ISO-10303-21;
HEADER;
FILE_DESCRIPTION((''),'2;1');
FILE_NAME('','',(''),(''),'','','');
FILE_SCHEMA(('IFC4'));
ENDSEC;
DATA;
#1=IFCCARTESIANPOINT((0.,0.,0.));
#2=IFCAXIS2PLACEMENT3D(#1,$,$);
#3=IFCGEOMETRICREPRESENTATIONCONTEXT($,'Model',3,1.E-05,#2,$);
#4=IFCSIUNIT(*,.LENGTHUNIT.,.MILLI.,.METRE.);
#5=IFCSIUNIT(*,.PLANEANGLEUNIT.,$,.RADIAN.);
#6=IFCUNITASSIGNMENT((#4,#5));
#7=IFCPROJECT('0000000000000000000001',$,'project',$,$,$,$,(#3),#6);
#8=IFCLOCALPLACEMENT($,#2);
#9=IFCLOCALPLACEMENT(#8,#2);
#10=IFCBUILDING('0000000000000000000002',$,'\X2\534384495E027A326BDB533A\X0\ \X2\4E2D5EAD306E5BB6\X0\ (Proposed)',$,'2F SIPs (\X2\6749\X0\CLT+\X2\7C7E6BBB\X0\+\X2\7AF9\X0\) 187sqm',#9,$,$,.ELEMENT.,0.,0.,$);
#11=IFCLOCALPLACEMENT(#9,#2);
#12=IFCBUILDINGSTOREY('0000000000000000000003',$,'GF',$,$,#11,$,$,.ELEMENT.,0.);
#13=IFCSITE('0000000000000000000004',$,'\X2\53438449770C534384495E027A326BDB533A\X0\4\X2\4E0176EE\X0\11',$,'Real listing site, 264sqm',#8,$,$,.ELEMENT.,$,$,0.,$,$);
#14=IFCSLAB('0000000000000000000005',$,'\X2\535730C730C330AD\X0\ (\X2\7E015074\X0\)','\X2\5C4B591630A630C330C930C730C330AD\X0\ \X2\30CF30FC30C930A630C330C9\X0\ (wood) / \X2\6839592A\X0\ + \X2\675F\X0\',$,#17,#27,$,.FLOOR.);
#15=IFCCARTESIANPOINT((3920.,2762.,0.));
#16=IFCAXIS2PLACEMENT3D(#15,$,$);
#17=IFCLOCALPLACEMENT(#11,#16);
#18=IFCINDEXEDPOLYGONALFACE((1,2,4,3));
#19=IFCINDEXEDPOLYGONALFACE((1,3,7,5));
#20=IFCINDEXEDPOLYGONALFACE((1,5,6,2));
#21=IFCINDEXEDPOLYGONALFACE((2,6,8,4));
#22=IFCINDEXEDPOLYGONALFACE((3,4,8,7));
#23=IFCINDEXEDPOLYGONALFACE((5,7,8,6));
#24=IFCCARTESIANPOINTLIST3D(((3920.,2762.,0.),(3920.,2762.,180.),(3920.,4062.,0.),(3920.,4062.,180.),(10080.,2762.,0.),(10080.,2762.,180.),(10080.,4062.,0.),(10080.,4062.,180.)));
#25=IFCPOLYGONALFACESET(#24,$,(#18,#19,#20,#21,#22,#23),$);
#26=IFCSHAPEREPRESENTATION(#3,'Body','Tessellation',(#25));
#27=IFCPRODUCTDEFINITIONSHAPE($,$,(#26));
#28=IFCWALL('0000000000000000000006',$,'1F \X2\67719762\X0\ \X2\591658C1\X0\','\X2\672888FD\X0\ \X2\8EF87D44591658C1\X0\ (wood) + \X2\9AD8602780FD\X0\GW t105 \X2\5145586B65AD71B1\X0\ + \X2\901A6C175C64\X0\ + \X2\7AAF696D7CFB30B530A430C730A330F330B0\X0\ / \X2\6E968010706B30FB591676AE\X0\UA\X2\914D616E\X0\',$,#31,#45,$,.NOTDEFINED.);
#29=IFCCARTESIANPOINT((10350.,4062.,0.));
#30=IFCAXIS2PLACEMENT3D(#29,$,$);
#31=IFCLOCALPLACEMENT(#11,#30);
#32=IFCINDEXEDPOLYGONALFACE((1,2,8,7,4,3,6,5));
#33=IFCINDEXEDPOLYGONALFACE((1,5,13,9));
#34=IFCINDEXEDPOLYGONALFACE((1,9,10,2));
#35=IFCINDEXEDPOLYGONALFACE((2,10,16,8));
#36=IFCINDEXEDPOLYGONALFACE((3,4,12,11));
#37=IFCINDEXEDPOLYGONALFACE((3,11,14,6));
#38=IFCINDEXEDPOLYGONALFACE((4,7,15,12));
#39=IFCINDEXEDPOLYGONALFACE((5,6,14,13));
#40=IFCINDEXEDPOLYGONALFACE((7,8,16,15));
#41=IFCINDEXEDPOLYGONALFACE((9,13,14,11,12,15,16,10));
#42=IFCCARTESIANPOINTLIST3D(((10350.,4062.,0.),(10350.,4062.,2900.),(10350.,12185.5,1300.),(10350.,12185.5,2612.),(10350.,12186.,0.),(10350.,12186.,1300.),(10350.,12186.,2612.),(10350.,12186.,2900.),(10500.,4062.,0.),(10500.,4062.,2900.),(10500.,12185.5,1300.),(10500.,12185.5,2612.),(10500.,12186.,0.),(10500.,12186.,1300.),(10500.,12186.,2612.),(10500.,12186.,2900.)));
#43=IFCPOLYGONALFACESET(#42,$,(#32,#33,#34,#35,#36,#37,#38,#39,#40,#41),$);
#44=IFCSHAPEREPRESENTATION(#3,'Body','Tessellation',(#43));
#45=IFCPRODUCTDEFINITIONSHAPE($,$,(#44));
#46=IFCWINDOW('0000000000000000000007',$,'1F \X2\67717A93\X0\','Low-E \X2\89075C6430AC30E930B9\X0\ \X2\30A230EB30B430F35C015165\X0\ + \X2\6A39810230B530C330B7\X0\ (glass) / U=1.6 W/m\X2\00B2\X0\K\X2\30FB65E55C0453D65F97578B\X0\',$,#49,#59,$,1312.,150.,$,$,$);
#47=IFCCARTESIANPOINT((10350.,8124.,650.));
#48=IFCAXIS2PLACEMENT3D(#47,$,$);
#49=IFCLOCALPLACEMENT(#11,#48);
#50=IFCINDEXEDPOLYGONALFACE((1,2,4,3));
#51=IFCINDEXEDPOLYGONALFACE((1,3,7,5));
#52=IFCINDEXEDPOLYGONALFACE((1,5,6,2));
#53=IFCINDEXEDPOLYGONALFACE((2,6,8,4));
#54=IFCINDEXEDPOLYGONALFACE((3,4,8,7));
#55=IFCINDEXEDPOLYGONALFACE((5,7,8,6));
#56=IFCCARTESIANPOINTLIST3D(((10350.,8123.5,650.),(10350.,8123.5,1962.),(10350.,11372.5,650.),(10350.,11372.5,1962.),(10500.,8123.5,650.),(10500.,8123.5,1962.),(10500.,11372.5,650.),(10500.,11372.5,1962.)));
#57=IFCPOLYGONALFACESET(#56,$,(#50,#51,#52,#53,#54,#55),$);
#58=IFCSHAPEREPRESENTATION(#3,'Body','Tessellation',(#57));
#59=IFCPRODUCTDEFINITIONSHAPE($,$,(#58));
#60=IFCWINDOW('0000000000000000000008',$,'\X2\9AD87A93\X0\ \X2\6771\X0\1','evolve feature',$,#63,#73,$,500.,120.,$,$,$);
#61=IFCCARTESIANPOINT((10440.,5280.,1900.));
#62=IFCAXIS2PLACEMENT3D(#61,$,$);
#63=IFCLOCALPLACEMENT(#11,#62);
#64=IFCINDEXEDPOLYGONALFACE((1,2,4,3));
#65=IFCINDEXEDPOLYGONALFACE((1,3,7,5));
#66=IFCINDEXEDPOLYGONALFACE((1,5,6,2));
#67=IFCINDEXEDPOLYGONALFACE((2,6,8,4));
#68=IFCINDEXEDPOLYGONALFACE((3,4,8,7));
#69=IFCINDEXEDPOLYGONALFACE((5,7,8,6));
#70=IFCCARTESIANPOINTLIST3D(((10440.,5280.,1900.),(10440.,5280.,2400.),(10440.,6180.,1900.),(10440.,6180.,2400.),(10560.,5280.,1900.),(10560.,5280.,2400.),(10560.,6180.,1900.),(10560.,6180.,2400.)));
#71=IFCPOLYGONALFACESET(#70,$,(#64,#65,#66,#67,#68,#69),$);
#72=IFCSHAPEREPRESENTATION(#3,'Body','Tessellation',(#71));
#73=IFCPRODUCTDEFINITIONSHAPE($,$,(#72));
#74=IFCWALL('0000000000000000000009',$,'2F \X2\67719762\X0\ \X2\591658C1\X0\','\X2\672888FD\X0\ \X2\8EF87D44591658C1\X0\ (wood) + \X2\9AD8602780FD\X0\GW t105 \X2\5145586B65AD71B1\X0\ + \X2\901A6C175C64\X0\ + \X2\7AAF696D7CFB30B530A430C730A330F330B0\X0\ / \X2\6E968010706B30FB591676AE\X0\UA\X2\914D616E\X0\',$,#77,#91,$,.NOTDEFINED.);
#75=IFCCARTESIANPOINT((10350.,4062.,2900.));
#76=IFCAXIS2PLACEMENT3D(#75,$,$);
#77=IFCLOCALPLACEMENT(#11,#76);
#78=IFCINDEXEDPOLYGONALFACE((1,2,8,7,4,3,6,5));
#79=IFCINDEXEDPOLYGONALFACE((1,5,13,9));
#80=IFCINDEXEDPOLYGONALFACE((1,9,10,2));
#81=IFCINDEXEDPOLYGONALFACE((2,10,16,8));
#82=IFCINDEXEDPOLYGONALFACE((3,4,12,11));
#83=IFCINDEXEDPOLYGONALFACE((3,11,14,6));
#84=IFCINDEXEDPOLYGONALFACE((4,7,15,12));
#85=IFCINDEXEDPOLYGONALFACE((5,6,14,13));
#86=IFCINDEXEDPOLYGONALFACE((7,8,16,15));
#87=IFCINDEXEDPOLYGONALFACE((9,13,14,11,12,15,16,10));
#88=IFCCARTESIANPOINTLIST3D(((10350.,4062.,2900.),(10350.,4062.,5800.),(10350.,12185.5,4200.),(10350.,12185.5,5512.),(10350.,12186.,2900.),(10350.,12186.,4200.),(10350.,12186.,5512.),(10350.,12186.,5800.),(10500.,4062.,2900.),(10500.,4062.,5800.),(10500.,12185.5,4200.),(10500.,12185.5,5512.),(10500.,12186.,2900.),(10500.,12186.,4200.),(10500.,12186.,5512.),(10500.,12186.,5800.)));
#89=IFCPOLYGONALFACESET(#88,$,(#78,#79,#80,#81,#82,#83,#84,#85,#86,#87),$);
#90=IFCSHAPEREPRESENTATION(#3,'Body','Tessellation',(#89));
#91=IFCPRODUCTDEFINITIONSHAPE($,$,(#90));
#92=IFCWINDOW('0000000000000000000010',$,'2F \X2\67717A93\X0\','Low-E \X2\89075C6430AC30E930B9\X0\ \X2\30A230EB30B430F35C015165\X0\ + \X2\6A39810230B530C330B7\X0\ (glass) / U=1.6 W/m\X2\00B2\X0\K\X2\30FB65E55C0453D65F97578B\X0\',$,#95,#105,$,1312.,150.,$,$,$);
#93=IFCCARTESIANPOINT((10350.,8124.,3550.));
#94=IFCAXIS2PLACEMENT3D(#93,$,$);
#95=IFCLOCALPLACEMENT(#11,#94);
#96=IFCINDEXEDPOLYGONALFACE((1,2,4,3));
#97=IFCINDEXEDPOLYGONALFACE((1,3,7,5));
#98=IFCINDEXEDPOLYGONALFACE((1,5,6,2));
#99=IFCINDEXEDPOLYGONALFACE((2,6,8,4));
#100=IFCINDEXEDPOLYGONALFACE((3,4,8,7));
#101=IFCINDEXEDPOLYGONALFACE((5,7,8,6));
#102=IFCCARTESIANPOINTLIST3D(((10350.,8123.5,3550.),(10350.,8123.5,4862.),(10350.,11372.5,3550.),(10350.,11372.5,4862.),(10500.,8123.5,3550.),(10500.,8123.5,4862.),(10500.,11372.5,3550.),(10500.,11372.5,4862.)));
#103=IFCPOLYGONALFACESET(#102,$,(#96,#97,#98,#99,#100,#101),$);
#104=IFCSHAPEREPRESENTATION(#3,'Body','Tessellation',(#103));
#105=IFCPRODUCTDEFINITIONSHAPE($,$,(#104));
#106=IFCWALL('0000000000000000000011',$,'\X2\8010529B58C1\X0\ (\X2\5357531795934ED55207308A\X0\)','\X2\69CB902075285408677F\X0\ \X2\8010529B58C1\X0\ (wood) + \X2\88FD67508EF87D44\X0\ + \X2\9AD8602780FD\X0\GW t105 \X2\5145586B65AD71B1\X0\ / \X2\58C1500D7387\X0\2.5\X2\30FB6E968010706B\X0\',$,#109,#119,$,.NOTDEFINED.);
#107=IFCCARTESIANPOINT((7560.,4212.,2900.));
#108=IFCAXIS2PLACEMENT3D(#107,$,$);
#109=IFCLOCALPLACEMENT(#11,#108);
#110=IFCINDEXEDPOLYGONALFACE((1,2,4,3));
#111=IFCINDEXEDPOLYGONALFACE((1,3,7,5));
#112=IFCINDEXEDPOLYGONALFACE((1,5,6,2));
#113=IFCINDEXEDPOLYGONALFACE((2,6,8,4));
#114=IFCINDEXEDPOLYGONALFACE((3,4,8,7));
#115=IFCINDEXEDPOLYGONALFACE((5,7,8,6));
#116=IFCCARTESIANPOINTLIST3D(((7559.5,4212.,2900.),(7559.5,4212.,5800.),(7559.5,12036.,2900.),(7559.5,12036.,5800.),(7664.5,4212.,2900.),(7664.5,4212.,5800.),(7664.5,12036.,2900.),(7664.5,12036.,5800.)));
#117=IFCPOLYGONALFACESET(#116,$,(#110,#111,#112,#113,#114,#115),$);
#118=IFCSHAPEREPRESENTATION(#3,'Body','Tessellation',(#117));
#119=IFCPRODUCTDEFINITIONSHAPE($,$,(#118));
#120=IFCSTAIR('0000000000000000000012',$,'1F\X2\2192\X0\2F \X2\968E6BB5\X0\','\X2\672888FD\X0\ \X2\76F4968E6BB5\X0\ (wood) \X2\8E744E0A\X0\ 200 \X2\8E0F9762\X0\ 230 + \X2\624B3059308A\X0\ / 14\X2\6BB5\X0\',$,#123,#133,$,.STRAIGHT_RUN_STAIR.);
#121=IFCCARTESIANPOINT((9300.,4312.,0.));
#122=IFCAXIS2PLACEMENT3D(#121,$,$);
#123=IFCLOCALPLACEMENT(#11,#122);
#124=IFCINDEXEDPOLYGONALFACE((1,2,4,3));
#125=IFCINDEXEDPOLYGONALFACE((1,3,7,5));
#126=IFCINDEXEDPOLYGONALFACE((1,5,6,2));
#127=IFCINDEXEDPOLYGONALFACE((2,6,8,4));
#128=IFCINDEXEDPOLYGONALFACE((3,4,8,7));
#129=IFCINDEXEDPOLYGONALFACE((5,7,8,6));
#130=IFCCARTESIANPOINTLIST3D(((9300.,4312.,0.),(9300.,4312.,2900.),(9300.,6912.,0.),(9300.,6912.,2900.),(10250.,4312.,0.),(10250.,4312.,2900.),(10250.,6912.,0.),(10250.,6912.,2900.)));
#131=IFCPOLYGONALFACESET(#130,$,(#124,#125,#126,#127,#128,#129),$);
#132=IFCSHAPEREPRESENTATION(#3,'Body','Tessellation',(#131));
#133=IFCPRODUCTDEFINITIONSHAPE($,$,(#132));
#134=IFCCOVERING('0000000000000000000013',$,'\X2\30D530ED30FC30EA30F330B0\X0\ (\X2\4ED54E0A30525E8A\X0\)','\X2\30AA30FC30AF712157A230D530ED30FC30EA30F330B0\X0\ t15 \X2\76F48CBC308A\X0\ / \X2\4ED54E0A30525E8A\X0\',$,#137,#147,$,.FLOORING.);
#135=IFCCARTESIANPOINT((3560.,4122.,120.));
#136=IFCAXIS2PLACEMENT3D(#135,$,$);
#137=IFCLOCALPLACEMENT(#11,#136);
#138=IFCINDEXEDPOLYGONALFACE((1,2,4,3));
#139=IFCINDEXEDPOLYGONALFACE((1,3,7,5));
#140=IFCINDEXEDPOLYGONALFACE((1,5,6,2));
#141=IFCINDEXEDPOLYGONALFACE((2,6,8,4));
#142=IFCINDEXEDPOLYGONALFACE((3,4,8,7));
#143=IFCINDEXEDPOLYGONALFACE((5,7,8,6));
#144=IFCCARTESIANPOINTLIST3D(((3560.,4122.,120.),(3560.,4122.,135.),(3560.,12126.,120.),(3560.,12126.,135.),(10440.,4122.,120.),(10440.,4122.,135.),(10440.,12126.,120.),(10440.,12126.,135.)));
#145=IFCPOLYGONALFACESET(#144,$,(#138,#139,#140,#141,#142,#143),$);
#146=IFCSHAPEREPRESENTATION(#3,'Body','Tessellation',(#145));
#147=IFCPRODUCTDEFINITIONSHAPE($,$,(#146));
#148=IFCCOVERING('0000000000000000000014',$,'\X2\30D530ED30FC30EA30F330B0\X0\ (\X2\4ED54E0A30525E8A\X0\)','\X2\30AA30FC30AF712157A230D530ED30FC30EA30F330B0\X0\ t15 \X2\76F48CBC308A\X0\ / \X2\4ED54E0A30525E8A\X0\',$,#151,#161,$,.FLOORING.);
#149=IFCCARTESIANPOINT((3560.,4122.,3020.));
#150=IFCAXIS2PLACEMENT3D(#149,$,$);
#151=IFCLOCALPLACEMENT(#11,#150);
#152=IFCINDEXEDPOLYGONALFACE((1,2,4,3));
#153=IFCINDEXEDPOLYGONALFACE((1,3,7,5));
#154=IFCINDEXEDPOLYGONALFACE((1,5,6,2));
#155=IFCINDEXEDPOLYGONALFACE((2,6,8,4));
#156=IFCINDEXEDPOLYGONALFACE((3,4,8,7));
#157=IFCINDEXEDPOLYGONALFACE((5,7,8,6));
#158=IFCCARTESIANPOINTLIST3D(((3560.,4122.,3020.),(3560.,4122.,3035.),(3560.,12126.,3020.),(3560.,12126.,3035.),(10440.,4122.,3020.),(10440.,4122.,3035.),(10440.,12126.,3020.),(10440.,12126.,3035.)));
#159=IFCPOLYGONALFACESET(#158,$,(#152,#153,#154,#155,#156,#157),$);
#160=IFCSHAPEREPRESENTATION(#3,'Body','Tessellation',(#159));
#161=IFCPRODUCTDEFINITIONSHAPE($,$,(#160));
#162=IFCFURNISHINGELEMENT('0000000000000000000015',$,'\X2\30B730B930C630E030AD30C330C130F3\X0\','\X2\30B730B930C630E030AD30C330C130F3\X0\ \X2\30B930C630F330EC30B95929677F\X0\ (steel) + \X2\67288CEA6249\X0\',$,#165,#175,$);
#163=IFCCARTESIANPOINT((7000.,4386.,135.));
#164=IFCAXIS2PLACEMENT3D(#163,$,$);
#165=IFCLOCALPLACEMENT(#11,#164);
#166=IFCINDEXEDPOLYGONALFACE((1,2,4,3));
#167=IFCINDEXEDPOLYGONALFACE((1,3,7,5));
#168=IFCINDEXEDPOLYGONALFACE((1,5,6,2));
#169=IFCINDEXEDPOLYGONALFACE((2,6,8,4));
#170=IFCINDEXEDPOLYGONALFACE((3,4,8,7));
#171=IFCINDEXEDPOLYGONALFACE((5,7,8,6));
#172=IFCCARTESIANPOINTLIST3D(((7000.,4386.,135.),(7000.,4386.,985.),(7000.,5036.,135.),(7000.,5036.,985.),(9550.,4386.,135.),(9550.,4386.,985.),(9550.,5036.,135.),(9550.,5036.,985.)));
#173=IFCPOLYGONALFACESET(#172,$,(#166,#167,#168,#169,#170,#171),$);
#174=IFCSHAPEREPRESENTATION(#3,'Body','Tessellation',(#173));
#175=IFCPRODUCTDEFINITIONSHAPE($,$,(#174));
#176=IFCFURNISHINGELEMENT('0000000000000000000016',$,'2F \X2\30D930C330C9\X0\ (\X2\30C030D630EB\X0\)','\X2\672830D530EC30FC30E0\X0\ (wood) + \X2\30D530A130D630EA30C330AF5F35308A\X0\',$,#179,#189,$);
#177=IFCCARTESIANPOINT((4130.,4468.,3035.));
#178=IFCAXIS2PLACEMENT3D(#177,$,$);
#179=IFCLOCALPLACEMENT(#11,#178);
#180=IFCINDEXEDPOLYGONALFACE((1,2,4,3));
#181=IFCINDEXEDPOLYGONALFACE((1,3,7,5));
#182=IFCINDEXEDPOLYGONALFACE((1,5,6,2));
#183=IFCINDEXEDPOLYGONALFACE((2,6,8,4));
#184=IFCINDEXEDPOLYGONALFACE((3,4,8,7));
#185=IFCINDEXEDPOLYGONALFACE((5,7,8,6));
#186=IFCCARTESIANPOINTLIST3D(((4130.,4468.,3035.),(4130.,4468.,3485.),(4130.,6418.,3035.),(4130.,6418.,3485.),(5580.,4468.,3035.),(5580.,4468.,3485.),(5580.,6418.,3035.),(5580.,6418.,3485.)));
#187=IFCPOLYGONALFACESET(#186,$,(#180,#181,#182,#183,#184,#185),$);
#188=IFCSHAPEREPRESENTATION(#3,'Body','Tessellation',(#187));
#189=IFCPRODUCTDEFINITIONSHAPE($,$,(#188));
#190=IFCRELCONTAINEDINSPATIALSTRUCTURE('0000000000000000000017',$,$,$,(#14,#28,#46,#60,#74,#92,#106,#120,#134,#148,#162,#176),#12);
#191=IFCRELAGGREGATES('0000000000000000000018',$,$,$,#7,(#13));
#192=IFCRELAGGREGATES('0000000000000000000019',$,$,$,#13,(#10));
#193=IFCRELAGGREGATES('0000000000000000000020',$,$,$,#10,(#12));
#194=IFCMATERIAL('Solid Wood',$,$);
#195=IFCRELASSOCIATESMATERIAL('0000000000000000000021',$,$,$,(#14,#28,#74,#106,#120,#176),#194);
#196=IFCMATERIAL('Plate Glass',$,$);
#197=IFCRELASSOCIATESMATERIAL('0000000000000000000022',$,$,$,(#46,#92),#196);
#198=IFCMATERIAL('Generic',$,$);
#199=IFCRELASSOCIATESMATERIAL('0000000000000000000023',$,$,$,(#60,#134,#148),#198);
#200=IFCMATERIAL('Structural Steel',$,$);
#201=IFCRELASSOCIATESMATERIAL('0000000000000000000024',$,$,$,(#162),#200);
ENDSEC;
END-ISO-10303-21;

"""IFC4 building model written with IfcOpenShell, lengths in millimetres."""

from ifc_helpers import new_model, si_unit, frame, frame_2d, origin, place, context, project, spatial, rectangle, extrude, material, element, fill, save


model = new_model("IFC4")

# Units and contexts
model_context = context("Model", 3, precision=1e-05, world=origin())
ifc_project = project(units=[si_unit("LENGTHUNIT", "METRE", prefix="MILLI"), si_unit("PLANEANGLEUNIT", "RADIAN")], contexts=[model_context])

# Site, building, storey
site_placement = place(None, origin())
site = spatial("IfcSite", under=ifc_project, at=site_placement, Name="千葉県千葉市稲毛区4丁目11", ObjectType="Real listing site, 264sqm", CompositionType="ELEMENT", RefElevation=0.0)
building_placement = place(site_placement, origin())
building = spatial("IfcBuilding", under=site, at=building_placement, Name="千葉市稲毛区 中庭の家 (Proposed)", ObjectType="2F SIPs (杉CLT+籾殻+竹) 187sqm", CompositionType="ELEMENT", ElevationOfRefHeight=0.0, ElevationOfTerrain=0.0)
storey_placement = place(building_placement, origin())
storey = spatial("IfcBuildingStorey", under=building, at=storey_placement, Name="GF", CompositionType="ELEMENT", Elevation=0.0)

# Slab
ifc_material_1 = material(Name="Solid Wood")
slab_placement = place(storey_placement, frame((3920.0, 2762.0, 0.0)))
element("IfcSlab", 1, at=slab_placement, inside=storey, material=ifc_material_1, Name="南デッキ (縁側)", Description="屋外ウッドデッキ ハードウッド (wood) / 根太 + 束", PredefinedType="FLOOR", context=model_context, shape_type="SweptSolid", body=[
    extrude(rectangle(XDim=6160.0, YDim=1300.0, at=frame_2d((3080.0, 650.0))), frame((3920.0, 2762.0, 0.0)), (0.0, 0.0, 1.0), 180.0),
])

# Wall, openings, windows
wall_1_placement = place(storey_placement, frame((10350.0, 4062.0, 0.0)))
wall_1 = element("IfcWall", 2, at=wall_1_placement, inside=storey, material=ifc_material_1, Name="1F 東面 外壁", Description="木製 軸組外壁 (wood) + 高性能GW t105 充填断熱 + 通気層 + 窯業系サイディング / 準耐火・外皮UA配慮", PredefinedType="NOTDEFINED", context=model_context, shape_type="SweptSolid", body=[
    extrude(rectangle(XDim=150.0, YDim=8124.0, at=frame_2d((75.0, 4062.0))), frame((10350.0, 4062.0, 0.0)), (0.0, 0.0, 1.0), 2900.0),
])
opening_1_placement = place(storey_placement, frame((10350.0, 8124.0, 650.0)))
opening_1 = element("IfcOpeningElement", 3, at=opening_1_placement, cuts=wall_1, PredefinedType="NOTDEFINED", context=model_context, shape_type="SweptSolid", body=[
    extrude(rectangle(XDim=150.0, YDim=3249.0, at=frame_2d((75.0, 1624.0))), frame((10350.0, 8124.0, 650.0)), (0.0, 0.0, 1.0), 1312.0),
])
opening_2_placement = place(storey_placement, frame((10440.0, 5280.0, 1900.0)))
opening_2 = element("IfcOpeningElement", 4, at=opening_2_placement, cuts=wall_1, PredefinedType="NOTDEFINED", context=model_context, shape_type="SweptSolid", body=[
    extrude(rectangle(XDim=120.0, YDim=900.0, at=frame_2d((60.0, 450.0))), frame((10440.0, 5280.0, 1900.0)), (0.0, 0.0, 1.0), 500.0),
])
ifc_material_2 = material(Name="Plate Glass")
window_1_placement = place(storey_placement, frame((10350.0, 8124.0, 650.0)))
window_1 = element("IfcWindow", 5, at=window_1_placement, inside=storey, material=ifc_material_2, Name="1F 東窓", Description="Low-E 複層ガラス アルゴン封入 + 樹脂サッシ (glass) / U=1.6 W/m²K・日射取得型", OverallHeight=1312.0, OverallWidth=150.0, context=model_context, shape_type="SweptSolid", body=[
    extrude(rectangle(XDim=150.0, YDim=3249.0, at=frame_2d((75.0, 1624.0))), frame((10350.0, 8124.0, 650.0)), (0.0, 0.0, 1.0), 1312.0),
])
fill(opening_1, window_1)
ifc_material_3 = material(Name="Generic")
window_2_placement = place(storey_placement, frame((10440.0, 5280.0, 1900.0)))
window_2 = element("IfcWindow", 6, at=window_2_placement, inside=storey, material=ifc_material_3, Name="高窓 東1", Description="evolve feature", OverallHeight=500.0, OverallWidth=120.0, context=model_context, shape_type="SweptSolid", body=[
    extrude(rectangle(XDim=120.0, YDim=900.0, at=frame_2d((60.0, 450.0))), frame((10440.0, 5280.0, 1900.0)), (0.0, 0.0, 1.0), 500.0),
])
fill(opening_2, window_2)

# Wall, opening, window
wall_2_placement = place(storey_placement, frame((10350.0, 4062.0, 2900.0)))
wall_2 = element("IfcWall", 7, at=wall_2_placement, inside=storey, material=ifc_material_1, Name="2F 東面 外壁", Description="木製 軸組外壁 (wood) + 高性能GW t105 充填断熱 + 通気層 + 窯業系サイディング / 準耐火・外皮UA配慮", PredefinedType="NOTDEFINED", context=model_context, shape_type="SweptSolid", body=[
    extrude(rectangle(XDim=150.0, YDim=8124.0, at=frame_2d((75.0, 4062.0))), frame((10350.0, 4062.0, 2900.0)), (0.0, 0.0, 1.0), 2900.0),
])
opening_3_placement = place(storey_placement, frame((10350.0, 8124.0, 3550.0)))
opening_3 = element("IfcOpeningElement", 8, at=opening_3_placement, cuts=wall_2, PredefinedType="NOTDEFINED", context=model_context, shape_type="SweptSolid", body=[
    extrude(rectangle(XDim=150.0, YDim=3249.0, at=frame_2d((75.0, 1624.0))), frame((10350.0, 8124.0, 3550.0)), (0.0, 0.0, 1.0), 1312.0),
])
window_3_placement = place(storey_placement, frame((10350.0, 8124.0, 3550.0)))
window_3 = element("IfcWindow", 9, at=window_3_placement, inside=storey, material=ifc_material_2, Name="2F 東窓", Description="Low-E 複層ガラス アルゴン封入 + 樹脂サッシ (glass) / U=1.6 W/m²K・日射取得型", OverallHeight=1312.0, OverallWidth=150.0, context=model_context, shape_type="SweptSolid", body=[
    extrude(rectangle(XDim=150.0, YDim=3249.0, at=frame_2d((75.0, 1624.0))), frame((10350.0, 8124.0, 3550.0)), (0.0, 0.0, 1.0), 1312.0),
])
fill(opening_3, window_3)

# Wall
wall_3_placement = place(storey_placement, frame((7560.0, 4212.0, 2900.0)))
element("IfcWall", 10, at=wall_3_placement, inside=storey, material=ifc_material_1, Name="耐力壁 (南北間仕切り)", Description="構造用合板 耐力壁 (wood) + 製材軸組 + 高性能GW t105 充填断熱 / 壁倍率2.5・準耐火", PredefinedType="NOTDEFINED", context=model_context, shape_type="SweptSolid", body=[
    extrude(rectangle(XDim=105.0, YDim=7824.0, at=frame_2d((52.0, 3912.0))), frame((7560.0, 4212.0, 2900.0)), (0.0, 0.0, 1.0), 2900.0),
])

# Stair
stair_placement = place(storey_placement, frame((9300.0, 4312.0, 0.0)))
element("IfcStair", 11, at=stair_placement, inside=storey, material=ifc_material_1, Name="1F→2F 階段", Description="木製 直階段 (wood) 蹴上 200 踏面 230 + 手すり / 14段", PredefinedType="STRAIGHT_RUN_STAIR", context=model_context, shape_type="SweptSolid", body=[
    extrude(rectangle(XDim=950.0, YDim=2600.0, at=frame_2d((475.0, 1300.0))), frame((9300.0, 4312.0, 0.0)), (0.0, 0.0, 1.0), 2900.0),
])

# Coverings
covering_1_placement = place(storey_placement, frame((3560.0, 4122.0, 120.0)))
element("IfcCovering", 12, at=covering_1_placement, inside=storey, material=ifc_material_3, Name="フローリング (仕上げ床)", Description="オーク無垢フローリング t15 直貼り / 仕上げ床", PredefinedType="FLOORING", context=model_context, shape_type="SweptSolid", body=[
    extrude(rectangle(XDim=6880.0, YDim=8004.0, at=frame_2d((3440.0, 4002.0))), frame((3560.0, 4122.0, 120.0)), (0.0, 0.0, 1.0), 15.0),
])
covering_2_placement = place(storey_placement, frame((3560.0, 4122.0, 3020.0)))
element("IfcCovering", 13, at=covering_2_placement, inside=storey, material=ifc_material_3, Name="フローリング (仕上げ床)", Description="オーク無垢フローリング t15 直貼り / 仕上げ床", PredefinedType="FLOORING", context=model_context, shape_type="SweptSolid", body=[
    extrude(rectangle(XDim=6880.0, YDim=8004.0, at=frame_2d((3440.0, 4002.0))), frame((3560.0, 4122.0, 3020.0)), (0.0, 0.0, 1.0), 15.0),
])

# Furnishing elements
ifc_material_4 = material(Name="Structural Steel")
furnishing_1_placement = place(storey_placement, frame((7000.0, 4386.0, 135.0)))
element("IfcFurnishingElement", 14, at=furnishing_1_placement, inside=storey, material=ifc_material_4, Name="システムキッチン", Description="システムキッチン ステンレス天板 (steel) + 木質扉", context=model_context, shape_type="SweptSolid", body=[
    extrude(rectangle(XDim=2550.0, YDim=650.0, at=frame_2d((1275.0, 325.0))), frame((7000.0, 4386.0, 135.0)), (0.0, 0.0, 1.0), 850.0),
])
furnishing_2_placement = place(storey_placement, frame((4130.0, 4468.0, 3035.0)))
element("IfcFurnishingElement", 15, at=furnishing_2_placement, inside=storey, material=ifc_material_1, Name="2F ベッド (ダブル)", Description="木フレーム (wood) + ファブリック張り", context=model_context, shape_type="SweptSolid", body=[
    extrude(rectangle(XDim=1450.0, YDim=1950.0, at=frame_2d((725.0, 975.0))), frame((4130.0, 4468.0, 3035.0)), (0.0, 0.0, 1.0), 450.0),
])

save(model, "model.ifc")
